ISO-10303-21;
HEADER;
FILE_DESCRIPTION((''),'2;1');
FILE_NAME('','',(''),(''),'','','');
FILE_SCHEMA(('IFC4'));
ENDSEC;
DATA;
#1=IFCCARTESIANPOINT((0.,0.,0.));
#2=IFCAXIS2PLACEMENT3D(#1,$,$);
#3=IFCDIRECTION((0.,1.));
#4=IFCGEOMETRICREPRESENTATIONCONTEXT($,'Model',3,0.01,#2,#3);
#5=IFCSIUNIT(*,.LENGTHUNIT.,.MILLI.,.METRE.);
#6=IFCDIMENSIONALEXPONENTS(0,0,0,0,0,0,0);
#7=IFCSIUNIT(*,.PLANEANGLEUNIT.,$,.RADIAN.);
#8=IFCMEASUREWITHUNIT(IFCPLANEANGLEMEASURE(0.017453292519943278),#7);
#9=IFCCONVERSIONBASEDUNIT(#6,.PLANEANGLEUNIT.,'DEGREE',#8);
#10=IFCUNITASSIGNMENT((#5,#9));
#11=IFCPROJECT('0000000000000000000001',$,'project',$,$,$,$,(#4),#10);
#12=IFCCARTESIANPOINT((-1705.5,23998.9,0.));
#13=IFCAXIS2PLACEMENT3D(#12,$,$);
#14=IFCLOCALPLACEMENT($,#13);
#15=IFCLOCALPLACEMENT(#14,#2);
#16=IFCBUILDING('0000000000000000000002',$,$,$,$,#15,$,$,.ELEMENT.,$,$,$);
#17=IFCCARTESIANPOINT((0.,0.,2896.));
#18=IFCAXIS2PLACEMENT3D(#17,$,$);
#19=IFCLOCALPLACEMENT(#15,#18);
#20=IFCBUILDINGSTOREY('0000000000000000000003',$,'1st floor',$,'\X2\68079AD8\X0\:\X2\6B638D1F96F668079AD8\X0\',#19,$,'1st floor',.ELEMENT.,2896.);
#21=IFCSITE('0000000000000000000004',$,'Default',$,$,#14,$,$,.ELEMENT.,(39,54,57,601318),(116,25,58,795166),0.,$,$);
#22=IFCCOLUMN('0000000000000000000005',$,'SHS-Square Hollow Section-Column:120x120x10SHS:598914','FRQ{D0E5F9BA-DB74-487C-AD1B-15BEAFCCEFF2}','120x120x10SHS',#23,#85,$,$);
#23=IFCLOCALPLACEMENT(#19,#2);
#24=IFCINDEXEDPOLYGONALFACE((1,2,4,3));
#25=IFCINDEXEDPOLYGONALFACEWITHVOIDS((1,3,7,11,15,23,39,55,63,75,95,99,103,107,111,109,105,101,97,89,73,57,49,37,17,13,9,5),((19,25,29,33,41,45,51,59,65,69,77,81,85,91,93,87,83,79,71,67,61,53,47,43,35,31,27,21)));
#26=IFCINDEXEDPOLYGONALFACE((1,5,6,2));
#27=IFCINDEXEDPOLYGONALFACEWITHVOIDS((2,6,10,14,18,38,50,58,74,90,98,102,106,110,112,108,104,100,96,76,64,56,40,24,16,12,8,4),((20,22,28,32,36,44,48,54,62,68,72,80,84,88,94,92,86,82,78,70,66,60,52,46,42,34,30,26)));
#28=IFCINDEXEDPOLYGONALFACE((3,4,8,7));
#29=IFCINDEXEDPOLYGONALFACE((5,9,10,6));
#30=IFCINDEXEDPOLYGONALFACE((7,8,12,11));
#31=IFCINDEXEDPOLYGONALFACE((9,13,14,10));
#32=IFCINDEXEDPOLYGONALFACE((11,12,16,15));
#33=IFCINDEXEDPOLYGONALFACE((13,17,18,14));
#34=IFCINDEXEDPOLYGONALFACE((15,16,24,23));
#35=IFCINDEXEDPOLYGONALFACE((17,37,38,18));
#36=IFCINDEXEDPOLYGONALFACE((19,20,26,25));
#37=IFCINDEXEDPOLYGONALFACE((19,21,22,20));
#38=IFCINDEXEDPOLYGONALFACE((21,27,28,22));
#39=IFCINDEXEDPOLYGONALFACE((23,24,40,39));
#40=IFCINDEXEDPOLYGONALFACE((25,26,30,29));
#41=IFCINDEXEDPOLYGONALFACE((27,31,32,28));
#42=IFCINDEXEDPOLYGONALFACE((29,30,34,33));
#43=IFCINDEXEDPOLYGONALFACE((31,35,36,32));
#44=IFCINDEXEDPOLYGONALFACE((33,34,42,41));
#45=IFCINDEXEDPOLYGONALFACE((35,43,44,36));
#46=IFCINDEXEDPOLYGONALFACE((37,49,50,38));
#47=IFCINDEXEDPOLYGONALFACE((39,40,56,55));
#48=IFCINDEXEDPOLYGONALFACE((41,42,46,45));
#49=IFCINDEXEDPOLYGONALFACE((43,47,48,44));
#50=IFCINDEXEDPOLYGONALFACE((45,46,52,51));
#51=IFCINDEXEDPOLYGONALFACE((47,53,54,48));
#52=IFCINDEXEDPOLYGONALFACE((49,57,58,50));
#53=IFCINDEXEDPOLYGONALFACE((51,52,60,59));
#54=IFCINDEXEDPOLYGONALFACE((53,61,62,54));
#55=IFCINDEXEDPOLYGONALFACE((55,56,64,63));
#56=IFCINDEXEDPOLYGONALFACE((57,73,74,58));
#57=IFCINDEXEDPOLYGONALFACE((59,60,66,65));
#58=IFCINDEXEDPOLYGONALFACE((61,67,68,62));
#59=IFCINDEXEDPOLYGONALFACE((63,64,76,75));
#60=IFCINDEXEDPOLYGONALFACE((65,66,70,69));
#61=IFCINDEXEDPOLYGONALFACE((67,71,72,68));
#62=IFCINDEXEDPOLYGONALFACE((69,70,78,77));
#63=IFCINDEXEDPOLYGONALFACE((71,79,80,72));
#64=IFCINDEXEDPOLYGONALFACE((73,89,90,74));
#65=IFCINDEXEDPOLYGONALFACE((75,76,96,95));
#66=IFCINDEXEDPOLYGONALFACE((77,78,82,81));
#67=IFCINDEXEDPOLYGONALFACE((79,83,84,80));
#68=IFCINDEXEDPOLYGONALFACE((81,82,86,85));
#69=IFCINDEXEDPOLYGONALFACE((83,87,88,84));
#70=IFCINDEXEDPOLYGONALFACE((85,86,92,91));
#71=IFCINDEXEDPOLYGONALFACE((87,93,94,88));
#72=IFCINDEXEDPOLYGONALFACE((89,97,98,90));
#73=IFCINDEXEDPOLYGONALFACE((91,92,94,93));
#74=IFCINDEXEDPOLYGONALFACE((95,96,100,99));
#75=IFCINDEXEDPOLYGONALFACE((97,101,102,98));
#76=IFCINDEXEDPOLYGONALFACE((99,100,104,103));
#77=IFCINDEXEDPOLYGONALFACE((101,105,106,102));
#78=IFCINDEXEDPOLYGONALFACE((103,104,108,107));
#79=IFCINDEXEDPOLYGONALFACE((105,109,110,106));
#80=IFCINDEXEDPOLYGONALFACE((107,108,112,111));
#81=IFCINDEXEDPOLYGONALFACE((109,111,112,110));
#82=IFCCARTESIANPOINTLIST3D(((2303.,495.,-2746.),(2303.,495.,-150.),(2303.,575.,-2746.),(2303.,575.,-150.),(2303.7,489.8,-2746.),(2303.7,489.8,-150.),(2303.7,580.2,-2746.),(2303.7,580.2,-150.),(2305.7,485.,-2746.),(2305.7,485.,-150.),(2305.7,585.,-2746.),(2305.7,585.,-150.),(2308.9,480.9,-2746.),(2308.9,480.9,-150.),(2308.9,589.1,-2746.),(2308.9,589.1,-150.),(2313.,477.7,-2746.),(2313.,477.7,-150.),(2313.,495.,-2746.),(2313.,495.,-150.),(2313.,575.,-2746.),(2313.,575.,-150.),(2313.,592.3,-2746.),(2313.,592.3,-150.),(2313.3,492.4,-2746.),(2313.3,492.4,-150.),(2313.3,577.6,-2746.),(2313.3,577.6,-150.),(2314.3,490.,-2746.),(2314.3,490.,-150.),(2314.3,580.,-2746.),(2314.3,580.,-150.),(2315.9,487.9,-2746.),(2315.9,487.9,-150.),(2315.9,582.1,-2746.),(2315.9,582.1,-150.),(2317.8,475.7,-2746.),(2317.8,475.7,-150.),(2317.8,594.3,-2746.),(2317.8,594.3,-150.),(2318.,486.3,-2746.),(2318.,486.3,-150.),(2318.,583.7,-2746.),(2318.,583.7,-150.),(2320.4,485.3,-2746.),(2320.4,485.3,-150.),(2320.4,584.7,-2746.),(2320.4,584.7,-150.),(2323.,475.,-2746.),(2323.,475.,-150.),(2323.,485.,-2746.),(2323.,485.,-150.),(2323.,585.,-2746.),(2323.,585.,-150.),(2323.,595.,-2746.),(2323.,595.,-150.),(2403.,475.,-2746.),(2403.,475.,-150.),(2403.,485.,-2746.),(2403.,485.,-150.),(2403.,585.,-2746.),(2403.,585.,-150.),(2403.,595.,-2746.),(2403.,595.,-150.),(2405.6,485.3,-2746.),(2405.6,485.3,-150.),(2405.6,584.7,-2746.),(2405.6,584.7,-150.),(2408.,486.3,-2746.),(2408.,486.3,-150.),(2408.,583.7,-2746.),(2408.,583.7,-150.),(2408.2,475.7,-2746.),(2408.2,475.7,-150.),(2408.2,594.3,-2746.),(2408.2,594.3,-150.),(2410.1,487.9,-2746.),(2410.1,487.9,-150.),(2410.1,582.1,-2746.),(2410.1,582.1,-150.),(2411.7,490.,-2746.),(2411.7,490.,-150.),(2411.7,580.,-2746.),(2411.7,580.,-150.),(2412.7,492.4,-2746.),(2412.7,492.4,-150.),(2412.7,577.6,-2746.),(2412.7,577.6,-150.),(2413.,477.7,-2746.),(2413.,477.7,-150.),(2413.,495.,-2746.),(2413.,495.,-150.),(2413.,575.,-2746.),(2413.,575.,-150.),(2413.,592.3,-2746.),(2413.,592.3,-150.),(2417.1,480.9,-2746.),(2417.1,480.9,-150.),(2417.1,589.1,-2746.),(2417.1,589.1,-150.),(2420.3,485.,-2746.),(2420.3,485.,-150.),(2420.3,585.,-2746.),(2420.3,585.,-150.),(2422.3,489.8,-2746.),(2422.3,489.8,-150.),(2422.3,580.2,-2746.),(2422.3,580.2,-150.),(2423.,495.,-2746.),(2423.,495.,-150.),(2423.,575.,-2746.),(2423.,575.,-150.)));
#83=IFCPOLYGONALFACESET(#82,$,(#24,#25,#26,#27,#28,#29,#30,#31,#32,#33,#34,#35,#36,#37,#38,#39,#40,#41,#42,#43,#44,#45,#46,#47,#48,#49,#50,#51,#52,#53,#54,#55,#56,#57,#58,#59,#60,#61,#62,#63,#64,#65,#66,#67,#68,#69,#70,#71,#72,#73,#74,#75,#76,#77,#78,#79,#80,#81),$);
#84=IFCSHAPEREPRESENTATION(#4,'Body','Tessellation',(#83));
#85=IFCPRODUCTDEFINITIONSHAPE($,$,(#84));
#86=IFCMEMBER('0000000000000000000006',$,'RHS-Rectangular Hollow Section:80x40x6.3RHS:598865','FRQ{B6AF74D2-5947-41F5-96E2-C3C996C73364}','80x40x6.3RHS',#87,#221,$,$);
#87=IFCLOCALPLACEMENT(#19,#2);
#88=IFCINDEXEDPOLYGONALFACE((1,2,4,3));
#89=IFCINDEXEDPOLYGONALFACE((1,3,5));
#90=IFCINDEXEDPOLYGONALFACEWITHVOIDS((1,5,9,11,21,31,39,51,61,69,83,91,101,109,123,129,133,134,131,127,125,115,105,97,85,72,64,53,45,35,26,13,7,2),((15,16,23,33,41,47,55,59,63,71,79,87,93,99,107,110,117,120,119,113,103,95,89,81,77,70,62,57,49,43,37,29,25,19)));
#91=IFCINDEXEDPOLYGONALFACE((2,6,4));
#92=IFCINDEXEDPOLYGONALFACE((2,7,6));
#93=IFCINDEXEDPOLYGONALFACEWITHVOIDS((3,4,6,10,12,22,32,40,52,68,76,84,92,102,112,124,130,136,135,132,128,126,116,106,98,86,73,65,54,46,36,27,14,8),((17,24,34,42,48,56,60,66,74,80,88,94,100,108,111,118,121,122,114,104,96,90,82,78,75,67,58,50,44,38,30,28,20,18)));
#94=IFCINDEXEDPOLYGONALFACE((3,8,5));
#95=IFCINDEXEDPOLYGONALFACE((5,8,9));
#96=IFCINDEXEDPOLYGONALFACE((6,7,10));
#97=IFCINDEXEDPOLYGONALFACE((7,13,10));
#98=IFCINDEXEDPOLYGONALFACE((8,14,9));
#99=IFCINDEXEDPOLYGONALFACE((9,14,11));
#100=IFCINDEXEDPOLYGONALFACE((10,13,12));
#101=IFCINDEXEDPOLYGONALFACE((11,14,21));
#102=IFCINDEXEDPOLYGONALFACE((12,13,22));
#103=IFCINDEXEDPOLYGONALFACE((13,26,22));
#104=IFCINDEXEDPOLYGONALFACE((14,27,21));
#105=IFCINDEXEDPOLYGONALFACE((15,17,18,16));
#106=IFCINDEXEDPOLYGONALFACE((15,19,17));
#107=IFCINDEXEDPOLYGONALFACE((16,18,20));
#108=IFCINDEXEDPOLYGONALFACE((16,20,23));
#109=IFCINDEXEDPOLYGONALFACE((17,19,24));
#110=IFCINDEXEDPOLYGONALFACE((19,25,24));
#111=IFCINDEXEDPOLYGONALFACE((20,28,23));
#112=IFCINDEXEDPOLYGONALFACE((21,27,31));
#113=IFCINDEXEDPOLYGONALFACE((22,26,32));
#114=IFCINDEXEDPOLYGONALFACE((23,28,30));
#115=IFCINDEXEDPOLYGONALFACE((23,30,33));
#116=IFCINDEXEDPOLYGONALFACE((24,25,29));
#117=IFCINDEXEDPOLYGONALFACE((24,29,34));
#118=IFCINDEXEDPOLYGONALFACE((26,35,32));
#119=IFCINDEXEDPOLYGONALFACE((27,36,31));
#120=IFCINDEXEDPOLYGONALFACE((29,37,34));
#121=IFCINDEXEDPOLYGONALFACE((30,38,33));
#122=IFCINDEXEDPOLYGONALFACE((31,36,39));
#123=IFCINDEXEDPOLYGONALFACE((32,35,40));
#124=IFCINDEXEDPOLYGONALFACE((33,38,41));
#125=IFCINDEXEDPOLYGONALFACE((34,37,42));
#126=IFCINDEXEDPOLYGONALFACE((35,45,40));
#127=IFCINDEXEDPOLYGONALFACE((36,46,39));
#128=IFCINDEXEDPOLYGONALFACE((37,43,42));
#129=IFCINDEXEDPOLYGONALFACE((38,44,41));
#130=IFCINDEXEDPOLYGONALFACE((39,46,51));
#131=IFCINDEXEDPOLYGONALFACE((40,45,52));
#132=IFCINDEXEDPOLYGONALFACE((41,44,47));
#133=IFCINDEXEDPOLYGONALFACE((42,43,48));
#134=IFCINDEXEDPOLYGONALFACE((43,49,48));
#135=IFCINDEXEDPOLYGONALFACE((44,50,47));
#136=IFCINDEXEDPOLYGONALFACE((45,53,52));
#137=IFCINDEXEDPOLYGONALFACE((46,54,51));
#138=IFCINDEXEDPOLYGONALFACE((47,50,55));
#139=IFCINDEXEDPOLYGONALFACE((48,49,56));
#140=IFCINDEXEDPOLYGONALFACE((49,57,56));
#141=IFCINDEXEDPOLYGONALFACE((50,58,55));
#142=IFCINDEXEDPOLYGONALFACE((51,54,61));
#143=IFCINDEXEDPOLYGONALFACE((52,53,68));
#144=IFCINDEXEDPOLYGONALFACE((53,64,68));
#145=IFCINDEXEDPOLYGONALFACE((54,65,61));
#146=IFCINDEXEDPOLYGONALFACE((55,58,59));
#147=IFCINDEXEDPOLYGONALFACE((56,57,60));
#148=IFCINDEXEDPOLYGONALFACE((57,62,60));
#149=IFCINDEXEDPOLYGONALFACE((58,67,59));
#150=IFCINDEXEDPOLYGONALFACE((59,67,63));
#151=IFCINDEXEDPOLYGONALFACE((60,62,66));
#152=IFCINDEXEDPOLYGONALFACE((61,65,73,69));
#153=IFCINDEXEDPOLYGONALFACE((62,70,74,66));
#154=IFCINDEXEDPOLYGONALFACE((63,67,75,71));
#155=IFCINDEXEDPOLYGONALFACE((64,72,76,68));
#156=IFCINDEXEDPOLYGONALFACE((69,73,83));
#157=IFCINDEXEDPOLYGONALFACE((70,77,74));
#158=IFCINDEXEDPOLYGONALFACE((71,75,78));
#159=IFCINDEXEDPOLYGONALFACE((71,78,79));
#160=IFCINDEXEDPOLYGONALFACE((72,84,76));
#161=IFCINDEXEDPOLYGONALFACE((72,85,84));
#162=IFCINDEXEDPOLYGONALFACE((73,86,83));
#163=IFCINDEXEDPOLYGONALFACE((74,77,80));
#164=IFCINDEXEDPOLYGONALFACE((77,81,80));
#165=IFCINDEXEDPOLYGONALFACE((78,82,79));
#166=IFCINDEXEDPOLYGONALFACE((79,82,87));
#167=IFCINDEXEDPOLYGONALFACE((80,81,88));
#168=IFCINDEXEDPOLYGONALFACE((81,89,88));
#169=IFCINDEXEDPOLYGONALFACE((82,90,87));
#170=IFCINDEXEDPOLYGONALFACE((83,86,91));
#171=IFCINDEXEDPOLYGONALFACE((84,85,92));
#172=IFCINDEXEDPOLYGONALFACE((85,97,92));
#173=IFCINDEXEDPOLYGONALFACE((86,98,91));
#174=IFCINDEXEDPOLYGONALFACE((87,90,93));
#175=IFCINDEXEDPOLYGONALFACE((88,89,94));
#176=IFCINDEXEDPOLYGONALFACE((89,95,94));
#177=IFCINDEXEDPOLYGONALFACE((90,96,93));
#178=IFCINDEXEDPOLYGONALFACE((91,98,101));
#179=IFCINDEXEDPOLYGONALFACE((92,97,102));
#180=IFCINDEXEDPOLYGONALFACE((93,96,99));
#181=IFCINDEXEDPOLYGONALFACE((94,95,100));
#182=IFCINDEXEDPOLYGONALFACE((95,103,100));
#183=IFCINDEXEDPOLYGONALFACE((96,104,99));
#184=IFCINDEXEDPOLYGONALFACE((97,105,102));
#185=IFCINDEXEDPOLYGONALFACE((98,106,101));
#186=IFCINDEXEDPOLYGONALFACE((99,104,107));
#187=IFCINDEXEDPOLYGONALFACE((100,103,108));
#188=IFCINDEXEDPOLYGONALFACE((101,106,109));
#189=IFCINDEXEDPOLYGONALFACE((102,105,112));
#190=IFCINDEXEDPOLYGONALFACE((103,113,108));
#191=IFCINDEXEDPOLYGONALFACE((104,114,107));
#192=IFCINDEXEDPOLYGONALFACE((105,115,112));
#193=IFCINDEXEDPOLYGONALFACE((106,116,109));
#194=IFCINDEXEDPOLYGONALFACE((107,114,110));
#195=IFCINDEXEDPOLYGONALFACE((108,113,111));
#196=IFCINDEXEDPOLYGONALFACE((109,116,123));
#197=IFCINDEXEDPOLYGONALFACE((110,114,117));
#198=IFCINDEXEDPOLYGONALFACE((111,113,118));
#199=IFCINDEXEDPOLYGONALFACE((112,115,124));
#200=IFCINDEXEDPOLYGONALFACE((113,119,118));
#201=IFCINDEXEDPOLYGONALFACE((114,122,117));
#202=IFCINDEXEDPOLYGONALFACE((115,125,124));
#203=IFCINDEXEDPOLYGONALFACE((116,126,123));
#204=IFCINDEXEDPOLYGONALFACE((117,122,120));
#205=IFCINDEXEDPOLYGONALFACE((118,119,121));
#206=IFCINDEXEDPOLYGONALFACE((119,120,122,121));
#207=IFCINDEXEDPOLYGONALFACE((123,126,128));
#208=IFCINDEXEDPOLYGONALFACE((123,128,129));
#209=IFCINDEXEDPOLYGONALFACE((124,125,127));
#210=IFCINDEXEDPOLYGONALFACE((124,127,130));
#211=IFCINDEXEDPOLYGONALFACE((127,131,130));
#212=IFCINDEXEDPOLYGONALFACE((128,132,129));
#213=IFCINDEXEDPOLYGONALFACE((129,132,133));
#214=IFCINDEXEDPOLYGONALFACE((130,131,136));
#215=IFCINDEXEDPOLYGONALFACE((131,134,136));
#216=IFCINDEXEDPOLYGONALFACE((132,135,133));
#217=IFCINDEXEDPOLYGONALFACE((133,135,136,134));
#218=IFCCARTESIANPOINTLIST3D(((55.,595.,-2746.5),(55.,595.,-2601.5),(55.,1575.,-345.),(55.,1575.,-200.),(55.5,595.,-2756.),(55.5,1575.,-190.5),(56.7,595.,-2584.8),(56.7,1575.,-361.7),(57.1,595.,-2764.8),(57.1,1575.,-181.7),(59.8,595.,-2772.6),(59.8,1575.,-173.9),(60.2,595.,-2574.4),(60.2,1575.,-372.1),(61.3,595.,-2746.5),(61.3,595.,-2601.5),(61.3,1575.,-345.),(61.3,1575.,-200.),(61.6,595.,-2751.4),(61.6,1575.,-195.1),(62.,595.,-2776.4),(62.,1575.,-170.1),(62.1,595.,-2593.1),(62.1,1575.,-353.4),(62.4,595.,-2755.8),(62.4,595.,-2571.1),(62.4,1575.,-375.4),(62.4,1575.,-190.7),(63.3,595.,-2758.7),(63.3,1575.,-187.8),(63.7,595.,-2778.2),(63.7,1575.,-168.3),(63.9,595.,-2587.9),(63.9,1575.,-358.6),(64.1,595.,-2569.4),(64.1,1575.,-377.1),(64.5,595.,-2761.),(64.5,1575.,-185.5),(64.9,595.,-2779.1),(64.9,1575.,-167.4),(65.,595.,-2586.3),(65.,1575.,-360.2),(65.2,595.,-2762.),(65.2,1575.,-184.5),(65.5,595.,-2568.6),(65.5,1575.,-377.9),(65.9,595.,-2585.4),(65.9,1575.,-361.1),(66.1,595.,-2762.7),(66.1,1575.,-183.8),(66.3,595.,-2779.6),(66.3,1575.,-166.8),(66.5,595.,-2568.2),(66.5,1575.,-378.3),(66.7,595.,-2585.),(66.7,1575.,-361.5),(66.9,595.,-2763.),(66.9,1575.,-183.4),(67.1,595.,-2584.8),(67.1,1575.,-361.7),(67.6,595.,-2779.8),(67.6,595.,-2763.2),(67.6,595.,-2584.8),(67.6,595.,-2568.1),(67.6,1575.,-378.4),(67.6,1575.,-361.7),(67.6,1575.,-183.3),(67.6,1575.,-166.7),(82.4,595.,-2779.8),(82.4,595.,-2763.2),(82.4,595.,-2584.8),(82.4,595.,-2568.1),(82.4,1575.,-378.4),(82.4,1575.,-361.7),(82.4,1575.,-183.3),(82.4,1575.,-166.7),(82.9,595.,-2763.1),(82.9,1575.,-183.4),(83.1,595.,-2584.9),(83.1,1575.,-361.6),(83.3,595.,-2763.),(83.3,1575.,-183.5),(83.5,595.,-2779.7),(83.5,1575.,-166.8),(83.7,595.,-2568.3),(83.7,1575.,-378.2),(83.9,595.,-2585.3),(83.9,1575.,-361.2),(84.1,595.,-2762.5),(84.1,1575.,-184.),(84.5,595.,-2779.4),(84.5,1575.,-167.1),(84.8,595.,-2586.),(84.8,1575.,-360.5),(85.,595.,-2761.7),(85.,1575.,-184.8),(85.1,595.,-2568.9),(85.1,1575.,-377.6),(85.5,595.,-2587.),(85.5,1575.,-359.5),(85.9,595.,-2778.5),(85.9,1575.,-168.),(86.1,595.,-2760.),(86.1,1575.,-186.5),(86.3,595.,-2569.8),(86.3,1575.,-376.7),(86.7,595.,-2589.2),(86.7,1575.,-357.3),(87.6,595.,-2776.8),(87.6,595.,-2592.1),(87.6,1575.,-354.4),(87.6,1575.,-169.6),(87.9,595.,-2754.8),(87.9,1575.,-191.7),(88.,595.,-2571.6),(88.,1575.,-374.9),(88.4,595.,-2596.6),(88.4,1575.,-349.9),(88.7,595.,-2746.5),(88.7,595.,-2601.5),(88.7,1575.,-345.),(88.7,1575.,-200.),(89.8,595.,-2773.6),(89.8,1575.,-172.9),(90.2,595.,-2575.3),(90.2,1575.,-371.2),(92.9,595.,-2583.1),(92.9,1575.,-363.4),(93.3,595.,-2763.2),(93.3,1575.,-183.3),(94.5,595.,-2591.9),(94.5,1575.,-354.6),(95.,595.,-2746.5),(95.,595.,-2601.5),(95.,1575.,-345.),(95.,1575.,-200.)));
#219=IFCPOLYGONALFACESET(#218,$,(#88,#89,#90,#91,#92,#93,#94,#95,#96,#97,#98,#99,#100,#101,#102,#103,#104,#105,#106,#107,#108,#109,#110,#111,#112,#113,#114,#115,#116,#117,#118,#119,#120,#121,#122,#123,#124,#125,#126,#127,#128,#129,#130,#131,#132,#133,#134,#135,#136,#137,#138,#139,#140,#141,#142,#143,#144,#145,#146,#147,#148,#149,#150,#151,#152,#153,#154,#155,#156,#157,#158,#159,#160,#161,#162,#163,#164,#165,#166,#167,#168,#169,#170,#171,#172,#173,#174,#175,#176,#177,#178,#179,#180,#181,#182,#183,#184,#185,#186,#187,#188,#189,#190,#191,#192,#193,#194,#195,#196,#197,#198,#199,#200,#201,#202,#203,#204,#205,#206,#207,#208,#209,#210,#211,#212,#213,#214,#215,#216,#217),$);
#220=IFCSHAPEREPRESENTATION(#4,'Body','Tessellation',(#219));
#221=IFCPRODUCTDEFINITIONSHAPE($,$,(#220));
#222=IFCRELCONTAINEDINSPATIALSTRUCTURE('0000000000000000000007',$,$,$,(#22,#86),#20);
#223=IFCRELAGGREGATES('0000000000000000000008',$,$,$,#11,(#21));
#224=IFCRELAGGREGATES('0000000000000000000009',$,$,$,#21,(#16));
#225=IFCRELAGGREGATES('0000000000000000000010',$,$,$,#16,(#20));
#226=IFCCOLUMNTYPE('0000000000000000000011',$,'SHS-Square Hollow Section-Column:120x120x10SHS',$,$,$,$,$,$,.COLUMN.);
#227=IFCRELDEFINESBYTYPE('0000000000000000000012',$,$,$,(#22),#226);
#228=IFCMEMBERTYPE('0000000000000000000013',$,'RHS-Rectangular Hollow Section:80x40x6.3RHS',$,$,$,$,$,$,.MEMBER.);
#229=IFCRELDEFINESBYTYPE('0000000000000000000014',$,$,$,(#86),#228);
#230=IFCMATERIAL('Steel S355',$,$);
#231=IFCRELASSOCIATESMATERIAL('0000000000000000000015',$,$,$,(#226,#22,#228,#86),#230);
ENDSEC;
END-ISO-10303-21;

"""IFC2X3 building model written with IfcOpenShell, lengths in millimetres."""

from ifc_helpers import new_model, entity, si_unit, converted_unit, direction, frame, origin, origin_2d, place, context, project, spatial, hollow_rectangle, extrude, clip, halfspace, material, type_object, element, save


model = new_model("IFC2X3")

# Units and contexts
model_context = context("Model", 3, precision=0.01, world=origin(), true_north=direction((0.0, 1.0)))
ifc_project = project(units=[si_unit("LENGTHUNIT", "METRE", prefix="MILLI"), converted_unit("PLANEANGLEUNIT", "DEGREE", entity("IfcPlaneAngleMeasure", 0.017453292519943278), si_unit("PLANEANGLEUNIT", "RADIAN"), dimensions=[0, 0, 0, 0, 0, 0, 0])], contexts=[model_context])

# Site, building, storey
site_placement = place(None, frame((-1705.5, 23998.9, 0.0)))
site = spatial("IfcSite", under=ifc_project, at=site_placement, Name="Default", CompositionType="ELEMENT", RefLatitude=(39, 54, 57, 601318), RefLongitude=(116, 25, 58, 795166), RefElevation=0.0)
building_placement = place(site_placement, origin())
building = spatial("IfcBuilding", under=site, at=building_placement, CompositionType="ELEMENT")
storey_placement = place(building_placement, frame((0.0, 0.0, 2896.0)))
storey = spatial("IfcBuildingStorey", under=building, at=storey_placement, Name="1st floor", ObjectType="标高:正负零标高", LongName="1st floor", CompositionType="ELEMENT", Elevation=2896.0)

# Shared definitions
ifc_material_1 = material(Name="Steel S355")

# Column
column_type_1 = type_object("IfcColumnType", Name="SHS-Square Hollow Section-Column:120x120x10SHS", PredefinedType="COLUMN", material=ifc_material_1)
column_1_placement = place(storey_placement, frame((2363.0, 535.0, -150.0), z_axis=(0.0, 0.0, 1.0), x_axis=(0.0, -1.0, 0.0)))
element("IfcColumn", 1, at=column_1_placement, inside=storey, type_object=column_type_1, material=ifc_material_1, Name="SHS-Square Hollow Section-Column:120x120x10SHS:598914", Description="FRQ{D0E5F9BA-DB74-487C-AD1B-15BEAFCCEFF2}", ObjectType="120x120x10SHS", context=model_context, shape_type="Clipping", body=[
    clip(extrude(hollow_rectangle(XDim=120.0, YDim=120.0, WallThickness=10.0, InnerFilletRadius=10.0, OuterFilletRadius=20.0, at=origin_2d()), origin(), (0.0, 0.0, -1.0), 2680.9), halfspace(frame((535.0, -2363.0, -2596.0), z_axis=(0.0, 0.0, 1.0), x_axis=(0.0, 1.0, 0.0)), True)),
])

# Member
member_type_1 = type_object("IfcMemberType", Name="RHS-Rectangular Hollow Section:80x40x6.3RHS", PredefinedType="MEMBER", material=ifc_material_1)
member_1_placement = place(storey_placement, frame((75.0, 490.3, -2930.6), z_axis=(0.0, -0.377836, -0.925872), x_axis=(1.0, 0.0, 0.0)))
element("IfcMember", 2, at=member_1_placement, inside=storey, type_object=member_type_1, material=ifc_material_1, Name="RHS-Rectangular Hollow Section:80x40x6.3RHS:598865", Description="FRQ{B6AF74D2-5947-41F5-96E2-C3C996C73364}", ObjectType="80x40x6.3RHS", context=model_context, shape_type="Clipping", body=[
    clip(clip(extrude(hollow_rectangle(XDim=40.0, YDim=80.0, WallThickness=6.3, InnerFilletRadius=6.3, OuterFilletRadius=12.6, at=origin_2d()), origin(), (0.0, 0.0, -1.0), 3121.6), halfspace(frame((-75.0, -83.9, -71.6), z_axis=(0.0, -0.925872, -0.377836), x_axis=(-1.0, 0.0, 0.0)), True)), halfspace(frame((-75.0, -991.2, -441.9), z_axis=(0.0, 0.925872, 0.377836), x_axis=(1.0, 0.0, 0.0)), True)),
])

save(model, "model.ifc")
